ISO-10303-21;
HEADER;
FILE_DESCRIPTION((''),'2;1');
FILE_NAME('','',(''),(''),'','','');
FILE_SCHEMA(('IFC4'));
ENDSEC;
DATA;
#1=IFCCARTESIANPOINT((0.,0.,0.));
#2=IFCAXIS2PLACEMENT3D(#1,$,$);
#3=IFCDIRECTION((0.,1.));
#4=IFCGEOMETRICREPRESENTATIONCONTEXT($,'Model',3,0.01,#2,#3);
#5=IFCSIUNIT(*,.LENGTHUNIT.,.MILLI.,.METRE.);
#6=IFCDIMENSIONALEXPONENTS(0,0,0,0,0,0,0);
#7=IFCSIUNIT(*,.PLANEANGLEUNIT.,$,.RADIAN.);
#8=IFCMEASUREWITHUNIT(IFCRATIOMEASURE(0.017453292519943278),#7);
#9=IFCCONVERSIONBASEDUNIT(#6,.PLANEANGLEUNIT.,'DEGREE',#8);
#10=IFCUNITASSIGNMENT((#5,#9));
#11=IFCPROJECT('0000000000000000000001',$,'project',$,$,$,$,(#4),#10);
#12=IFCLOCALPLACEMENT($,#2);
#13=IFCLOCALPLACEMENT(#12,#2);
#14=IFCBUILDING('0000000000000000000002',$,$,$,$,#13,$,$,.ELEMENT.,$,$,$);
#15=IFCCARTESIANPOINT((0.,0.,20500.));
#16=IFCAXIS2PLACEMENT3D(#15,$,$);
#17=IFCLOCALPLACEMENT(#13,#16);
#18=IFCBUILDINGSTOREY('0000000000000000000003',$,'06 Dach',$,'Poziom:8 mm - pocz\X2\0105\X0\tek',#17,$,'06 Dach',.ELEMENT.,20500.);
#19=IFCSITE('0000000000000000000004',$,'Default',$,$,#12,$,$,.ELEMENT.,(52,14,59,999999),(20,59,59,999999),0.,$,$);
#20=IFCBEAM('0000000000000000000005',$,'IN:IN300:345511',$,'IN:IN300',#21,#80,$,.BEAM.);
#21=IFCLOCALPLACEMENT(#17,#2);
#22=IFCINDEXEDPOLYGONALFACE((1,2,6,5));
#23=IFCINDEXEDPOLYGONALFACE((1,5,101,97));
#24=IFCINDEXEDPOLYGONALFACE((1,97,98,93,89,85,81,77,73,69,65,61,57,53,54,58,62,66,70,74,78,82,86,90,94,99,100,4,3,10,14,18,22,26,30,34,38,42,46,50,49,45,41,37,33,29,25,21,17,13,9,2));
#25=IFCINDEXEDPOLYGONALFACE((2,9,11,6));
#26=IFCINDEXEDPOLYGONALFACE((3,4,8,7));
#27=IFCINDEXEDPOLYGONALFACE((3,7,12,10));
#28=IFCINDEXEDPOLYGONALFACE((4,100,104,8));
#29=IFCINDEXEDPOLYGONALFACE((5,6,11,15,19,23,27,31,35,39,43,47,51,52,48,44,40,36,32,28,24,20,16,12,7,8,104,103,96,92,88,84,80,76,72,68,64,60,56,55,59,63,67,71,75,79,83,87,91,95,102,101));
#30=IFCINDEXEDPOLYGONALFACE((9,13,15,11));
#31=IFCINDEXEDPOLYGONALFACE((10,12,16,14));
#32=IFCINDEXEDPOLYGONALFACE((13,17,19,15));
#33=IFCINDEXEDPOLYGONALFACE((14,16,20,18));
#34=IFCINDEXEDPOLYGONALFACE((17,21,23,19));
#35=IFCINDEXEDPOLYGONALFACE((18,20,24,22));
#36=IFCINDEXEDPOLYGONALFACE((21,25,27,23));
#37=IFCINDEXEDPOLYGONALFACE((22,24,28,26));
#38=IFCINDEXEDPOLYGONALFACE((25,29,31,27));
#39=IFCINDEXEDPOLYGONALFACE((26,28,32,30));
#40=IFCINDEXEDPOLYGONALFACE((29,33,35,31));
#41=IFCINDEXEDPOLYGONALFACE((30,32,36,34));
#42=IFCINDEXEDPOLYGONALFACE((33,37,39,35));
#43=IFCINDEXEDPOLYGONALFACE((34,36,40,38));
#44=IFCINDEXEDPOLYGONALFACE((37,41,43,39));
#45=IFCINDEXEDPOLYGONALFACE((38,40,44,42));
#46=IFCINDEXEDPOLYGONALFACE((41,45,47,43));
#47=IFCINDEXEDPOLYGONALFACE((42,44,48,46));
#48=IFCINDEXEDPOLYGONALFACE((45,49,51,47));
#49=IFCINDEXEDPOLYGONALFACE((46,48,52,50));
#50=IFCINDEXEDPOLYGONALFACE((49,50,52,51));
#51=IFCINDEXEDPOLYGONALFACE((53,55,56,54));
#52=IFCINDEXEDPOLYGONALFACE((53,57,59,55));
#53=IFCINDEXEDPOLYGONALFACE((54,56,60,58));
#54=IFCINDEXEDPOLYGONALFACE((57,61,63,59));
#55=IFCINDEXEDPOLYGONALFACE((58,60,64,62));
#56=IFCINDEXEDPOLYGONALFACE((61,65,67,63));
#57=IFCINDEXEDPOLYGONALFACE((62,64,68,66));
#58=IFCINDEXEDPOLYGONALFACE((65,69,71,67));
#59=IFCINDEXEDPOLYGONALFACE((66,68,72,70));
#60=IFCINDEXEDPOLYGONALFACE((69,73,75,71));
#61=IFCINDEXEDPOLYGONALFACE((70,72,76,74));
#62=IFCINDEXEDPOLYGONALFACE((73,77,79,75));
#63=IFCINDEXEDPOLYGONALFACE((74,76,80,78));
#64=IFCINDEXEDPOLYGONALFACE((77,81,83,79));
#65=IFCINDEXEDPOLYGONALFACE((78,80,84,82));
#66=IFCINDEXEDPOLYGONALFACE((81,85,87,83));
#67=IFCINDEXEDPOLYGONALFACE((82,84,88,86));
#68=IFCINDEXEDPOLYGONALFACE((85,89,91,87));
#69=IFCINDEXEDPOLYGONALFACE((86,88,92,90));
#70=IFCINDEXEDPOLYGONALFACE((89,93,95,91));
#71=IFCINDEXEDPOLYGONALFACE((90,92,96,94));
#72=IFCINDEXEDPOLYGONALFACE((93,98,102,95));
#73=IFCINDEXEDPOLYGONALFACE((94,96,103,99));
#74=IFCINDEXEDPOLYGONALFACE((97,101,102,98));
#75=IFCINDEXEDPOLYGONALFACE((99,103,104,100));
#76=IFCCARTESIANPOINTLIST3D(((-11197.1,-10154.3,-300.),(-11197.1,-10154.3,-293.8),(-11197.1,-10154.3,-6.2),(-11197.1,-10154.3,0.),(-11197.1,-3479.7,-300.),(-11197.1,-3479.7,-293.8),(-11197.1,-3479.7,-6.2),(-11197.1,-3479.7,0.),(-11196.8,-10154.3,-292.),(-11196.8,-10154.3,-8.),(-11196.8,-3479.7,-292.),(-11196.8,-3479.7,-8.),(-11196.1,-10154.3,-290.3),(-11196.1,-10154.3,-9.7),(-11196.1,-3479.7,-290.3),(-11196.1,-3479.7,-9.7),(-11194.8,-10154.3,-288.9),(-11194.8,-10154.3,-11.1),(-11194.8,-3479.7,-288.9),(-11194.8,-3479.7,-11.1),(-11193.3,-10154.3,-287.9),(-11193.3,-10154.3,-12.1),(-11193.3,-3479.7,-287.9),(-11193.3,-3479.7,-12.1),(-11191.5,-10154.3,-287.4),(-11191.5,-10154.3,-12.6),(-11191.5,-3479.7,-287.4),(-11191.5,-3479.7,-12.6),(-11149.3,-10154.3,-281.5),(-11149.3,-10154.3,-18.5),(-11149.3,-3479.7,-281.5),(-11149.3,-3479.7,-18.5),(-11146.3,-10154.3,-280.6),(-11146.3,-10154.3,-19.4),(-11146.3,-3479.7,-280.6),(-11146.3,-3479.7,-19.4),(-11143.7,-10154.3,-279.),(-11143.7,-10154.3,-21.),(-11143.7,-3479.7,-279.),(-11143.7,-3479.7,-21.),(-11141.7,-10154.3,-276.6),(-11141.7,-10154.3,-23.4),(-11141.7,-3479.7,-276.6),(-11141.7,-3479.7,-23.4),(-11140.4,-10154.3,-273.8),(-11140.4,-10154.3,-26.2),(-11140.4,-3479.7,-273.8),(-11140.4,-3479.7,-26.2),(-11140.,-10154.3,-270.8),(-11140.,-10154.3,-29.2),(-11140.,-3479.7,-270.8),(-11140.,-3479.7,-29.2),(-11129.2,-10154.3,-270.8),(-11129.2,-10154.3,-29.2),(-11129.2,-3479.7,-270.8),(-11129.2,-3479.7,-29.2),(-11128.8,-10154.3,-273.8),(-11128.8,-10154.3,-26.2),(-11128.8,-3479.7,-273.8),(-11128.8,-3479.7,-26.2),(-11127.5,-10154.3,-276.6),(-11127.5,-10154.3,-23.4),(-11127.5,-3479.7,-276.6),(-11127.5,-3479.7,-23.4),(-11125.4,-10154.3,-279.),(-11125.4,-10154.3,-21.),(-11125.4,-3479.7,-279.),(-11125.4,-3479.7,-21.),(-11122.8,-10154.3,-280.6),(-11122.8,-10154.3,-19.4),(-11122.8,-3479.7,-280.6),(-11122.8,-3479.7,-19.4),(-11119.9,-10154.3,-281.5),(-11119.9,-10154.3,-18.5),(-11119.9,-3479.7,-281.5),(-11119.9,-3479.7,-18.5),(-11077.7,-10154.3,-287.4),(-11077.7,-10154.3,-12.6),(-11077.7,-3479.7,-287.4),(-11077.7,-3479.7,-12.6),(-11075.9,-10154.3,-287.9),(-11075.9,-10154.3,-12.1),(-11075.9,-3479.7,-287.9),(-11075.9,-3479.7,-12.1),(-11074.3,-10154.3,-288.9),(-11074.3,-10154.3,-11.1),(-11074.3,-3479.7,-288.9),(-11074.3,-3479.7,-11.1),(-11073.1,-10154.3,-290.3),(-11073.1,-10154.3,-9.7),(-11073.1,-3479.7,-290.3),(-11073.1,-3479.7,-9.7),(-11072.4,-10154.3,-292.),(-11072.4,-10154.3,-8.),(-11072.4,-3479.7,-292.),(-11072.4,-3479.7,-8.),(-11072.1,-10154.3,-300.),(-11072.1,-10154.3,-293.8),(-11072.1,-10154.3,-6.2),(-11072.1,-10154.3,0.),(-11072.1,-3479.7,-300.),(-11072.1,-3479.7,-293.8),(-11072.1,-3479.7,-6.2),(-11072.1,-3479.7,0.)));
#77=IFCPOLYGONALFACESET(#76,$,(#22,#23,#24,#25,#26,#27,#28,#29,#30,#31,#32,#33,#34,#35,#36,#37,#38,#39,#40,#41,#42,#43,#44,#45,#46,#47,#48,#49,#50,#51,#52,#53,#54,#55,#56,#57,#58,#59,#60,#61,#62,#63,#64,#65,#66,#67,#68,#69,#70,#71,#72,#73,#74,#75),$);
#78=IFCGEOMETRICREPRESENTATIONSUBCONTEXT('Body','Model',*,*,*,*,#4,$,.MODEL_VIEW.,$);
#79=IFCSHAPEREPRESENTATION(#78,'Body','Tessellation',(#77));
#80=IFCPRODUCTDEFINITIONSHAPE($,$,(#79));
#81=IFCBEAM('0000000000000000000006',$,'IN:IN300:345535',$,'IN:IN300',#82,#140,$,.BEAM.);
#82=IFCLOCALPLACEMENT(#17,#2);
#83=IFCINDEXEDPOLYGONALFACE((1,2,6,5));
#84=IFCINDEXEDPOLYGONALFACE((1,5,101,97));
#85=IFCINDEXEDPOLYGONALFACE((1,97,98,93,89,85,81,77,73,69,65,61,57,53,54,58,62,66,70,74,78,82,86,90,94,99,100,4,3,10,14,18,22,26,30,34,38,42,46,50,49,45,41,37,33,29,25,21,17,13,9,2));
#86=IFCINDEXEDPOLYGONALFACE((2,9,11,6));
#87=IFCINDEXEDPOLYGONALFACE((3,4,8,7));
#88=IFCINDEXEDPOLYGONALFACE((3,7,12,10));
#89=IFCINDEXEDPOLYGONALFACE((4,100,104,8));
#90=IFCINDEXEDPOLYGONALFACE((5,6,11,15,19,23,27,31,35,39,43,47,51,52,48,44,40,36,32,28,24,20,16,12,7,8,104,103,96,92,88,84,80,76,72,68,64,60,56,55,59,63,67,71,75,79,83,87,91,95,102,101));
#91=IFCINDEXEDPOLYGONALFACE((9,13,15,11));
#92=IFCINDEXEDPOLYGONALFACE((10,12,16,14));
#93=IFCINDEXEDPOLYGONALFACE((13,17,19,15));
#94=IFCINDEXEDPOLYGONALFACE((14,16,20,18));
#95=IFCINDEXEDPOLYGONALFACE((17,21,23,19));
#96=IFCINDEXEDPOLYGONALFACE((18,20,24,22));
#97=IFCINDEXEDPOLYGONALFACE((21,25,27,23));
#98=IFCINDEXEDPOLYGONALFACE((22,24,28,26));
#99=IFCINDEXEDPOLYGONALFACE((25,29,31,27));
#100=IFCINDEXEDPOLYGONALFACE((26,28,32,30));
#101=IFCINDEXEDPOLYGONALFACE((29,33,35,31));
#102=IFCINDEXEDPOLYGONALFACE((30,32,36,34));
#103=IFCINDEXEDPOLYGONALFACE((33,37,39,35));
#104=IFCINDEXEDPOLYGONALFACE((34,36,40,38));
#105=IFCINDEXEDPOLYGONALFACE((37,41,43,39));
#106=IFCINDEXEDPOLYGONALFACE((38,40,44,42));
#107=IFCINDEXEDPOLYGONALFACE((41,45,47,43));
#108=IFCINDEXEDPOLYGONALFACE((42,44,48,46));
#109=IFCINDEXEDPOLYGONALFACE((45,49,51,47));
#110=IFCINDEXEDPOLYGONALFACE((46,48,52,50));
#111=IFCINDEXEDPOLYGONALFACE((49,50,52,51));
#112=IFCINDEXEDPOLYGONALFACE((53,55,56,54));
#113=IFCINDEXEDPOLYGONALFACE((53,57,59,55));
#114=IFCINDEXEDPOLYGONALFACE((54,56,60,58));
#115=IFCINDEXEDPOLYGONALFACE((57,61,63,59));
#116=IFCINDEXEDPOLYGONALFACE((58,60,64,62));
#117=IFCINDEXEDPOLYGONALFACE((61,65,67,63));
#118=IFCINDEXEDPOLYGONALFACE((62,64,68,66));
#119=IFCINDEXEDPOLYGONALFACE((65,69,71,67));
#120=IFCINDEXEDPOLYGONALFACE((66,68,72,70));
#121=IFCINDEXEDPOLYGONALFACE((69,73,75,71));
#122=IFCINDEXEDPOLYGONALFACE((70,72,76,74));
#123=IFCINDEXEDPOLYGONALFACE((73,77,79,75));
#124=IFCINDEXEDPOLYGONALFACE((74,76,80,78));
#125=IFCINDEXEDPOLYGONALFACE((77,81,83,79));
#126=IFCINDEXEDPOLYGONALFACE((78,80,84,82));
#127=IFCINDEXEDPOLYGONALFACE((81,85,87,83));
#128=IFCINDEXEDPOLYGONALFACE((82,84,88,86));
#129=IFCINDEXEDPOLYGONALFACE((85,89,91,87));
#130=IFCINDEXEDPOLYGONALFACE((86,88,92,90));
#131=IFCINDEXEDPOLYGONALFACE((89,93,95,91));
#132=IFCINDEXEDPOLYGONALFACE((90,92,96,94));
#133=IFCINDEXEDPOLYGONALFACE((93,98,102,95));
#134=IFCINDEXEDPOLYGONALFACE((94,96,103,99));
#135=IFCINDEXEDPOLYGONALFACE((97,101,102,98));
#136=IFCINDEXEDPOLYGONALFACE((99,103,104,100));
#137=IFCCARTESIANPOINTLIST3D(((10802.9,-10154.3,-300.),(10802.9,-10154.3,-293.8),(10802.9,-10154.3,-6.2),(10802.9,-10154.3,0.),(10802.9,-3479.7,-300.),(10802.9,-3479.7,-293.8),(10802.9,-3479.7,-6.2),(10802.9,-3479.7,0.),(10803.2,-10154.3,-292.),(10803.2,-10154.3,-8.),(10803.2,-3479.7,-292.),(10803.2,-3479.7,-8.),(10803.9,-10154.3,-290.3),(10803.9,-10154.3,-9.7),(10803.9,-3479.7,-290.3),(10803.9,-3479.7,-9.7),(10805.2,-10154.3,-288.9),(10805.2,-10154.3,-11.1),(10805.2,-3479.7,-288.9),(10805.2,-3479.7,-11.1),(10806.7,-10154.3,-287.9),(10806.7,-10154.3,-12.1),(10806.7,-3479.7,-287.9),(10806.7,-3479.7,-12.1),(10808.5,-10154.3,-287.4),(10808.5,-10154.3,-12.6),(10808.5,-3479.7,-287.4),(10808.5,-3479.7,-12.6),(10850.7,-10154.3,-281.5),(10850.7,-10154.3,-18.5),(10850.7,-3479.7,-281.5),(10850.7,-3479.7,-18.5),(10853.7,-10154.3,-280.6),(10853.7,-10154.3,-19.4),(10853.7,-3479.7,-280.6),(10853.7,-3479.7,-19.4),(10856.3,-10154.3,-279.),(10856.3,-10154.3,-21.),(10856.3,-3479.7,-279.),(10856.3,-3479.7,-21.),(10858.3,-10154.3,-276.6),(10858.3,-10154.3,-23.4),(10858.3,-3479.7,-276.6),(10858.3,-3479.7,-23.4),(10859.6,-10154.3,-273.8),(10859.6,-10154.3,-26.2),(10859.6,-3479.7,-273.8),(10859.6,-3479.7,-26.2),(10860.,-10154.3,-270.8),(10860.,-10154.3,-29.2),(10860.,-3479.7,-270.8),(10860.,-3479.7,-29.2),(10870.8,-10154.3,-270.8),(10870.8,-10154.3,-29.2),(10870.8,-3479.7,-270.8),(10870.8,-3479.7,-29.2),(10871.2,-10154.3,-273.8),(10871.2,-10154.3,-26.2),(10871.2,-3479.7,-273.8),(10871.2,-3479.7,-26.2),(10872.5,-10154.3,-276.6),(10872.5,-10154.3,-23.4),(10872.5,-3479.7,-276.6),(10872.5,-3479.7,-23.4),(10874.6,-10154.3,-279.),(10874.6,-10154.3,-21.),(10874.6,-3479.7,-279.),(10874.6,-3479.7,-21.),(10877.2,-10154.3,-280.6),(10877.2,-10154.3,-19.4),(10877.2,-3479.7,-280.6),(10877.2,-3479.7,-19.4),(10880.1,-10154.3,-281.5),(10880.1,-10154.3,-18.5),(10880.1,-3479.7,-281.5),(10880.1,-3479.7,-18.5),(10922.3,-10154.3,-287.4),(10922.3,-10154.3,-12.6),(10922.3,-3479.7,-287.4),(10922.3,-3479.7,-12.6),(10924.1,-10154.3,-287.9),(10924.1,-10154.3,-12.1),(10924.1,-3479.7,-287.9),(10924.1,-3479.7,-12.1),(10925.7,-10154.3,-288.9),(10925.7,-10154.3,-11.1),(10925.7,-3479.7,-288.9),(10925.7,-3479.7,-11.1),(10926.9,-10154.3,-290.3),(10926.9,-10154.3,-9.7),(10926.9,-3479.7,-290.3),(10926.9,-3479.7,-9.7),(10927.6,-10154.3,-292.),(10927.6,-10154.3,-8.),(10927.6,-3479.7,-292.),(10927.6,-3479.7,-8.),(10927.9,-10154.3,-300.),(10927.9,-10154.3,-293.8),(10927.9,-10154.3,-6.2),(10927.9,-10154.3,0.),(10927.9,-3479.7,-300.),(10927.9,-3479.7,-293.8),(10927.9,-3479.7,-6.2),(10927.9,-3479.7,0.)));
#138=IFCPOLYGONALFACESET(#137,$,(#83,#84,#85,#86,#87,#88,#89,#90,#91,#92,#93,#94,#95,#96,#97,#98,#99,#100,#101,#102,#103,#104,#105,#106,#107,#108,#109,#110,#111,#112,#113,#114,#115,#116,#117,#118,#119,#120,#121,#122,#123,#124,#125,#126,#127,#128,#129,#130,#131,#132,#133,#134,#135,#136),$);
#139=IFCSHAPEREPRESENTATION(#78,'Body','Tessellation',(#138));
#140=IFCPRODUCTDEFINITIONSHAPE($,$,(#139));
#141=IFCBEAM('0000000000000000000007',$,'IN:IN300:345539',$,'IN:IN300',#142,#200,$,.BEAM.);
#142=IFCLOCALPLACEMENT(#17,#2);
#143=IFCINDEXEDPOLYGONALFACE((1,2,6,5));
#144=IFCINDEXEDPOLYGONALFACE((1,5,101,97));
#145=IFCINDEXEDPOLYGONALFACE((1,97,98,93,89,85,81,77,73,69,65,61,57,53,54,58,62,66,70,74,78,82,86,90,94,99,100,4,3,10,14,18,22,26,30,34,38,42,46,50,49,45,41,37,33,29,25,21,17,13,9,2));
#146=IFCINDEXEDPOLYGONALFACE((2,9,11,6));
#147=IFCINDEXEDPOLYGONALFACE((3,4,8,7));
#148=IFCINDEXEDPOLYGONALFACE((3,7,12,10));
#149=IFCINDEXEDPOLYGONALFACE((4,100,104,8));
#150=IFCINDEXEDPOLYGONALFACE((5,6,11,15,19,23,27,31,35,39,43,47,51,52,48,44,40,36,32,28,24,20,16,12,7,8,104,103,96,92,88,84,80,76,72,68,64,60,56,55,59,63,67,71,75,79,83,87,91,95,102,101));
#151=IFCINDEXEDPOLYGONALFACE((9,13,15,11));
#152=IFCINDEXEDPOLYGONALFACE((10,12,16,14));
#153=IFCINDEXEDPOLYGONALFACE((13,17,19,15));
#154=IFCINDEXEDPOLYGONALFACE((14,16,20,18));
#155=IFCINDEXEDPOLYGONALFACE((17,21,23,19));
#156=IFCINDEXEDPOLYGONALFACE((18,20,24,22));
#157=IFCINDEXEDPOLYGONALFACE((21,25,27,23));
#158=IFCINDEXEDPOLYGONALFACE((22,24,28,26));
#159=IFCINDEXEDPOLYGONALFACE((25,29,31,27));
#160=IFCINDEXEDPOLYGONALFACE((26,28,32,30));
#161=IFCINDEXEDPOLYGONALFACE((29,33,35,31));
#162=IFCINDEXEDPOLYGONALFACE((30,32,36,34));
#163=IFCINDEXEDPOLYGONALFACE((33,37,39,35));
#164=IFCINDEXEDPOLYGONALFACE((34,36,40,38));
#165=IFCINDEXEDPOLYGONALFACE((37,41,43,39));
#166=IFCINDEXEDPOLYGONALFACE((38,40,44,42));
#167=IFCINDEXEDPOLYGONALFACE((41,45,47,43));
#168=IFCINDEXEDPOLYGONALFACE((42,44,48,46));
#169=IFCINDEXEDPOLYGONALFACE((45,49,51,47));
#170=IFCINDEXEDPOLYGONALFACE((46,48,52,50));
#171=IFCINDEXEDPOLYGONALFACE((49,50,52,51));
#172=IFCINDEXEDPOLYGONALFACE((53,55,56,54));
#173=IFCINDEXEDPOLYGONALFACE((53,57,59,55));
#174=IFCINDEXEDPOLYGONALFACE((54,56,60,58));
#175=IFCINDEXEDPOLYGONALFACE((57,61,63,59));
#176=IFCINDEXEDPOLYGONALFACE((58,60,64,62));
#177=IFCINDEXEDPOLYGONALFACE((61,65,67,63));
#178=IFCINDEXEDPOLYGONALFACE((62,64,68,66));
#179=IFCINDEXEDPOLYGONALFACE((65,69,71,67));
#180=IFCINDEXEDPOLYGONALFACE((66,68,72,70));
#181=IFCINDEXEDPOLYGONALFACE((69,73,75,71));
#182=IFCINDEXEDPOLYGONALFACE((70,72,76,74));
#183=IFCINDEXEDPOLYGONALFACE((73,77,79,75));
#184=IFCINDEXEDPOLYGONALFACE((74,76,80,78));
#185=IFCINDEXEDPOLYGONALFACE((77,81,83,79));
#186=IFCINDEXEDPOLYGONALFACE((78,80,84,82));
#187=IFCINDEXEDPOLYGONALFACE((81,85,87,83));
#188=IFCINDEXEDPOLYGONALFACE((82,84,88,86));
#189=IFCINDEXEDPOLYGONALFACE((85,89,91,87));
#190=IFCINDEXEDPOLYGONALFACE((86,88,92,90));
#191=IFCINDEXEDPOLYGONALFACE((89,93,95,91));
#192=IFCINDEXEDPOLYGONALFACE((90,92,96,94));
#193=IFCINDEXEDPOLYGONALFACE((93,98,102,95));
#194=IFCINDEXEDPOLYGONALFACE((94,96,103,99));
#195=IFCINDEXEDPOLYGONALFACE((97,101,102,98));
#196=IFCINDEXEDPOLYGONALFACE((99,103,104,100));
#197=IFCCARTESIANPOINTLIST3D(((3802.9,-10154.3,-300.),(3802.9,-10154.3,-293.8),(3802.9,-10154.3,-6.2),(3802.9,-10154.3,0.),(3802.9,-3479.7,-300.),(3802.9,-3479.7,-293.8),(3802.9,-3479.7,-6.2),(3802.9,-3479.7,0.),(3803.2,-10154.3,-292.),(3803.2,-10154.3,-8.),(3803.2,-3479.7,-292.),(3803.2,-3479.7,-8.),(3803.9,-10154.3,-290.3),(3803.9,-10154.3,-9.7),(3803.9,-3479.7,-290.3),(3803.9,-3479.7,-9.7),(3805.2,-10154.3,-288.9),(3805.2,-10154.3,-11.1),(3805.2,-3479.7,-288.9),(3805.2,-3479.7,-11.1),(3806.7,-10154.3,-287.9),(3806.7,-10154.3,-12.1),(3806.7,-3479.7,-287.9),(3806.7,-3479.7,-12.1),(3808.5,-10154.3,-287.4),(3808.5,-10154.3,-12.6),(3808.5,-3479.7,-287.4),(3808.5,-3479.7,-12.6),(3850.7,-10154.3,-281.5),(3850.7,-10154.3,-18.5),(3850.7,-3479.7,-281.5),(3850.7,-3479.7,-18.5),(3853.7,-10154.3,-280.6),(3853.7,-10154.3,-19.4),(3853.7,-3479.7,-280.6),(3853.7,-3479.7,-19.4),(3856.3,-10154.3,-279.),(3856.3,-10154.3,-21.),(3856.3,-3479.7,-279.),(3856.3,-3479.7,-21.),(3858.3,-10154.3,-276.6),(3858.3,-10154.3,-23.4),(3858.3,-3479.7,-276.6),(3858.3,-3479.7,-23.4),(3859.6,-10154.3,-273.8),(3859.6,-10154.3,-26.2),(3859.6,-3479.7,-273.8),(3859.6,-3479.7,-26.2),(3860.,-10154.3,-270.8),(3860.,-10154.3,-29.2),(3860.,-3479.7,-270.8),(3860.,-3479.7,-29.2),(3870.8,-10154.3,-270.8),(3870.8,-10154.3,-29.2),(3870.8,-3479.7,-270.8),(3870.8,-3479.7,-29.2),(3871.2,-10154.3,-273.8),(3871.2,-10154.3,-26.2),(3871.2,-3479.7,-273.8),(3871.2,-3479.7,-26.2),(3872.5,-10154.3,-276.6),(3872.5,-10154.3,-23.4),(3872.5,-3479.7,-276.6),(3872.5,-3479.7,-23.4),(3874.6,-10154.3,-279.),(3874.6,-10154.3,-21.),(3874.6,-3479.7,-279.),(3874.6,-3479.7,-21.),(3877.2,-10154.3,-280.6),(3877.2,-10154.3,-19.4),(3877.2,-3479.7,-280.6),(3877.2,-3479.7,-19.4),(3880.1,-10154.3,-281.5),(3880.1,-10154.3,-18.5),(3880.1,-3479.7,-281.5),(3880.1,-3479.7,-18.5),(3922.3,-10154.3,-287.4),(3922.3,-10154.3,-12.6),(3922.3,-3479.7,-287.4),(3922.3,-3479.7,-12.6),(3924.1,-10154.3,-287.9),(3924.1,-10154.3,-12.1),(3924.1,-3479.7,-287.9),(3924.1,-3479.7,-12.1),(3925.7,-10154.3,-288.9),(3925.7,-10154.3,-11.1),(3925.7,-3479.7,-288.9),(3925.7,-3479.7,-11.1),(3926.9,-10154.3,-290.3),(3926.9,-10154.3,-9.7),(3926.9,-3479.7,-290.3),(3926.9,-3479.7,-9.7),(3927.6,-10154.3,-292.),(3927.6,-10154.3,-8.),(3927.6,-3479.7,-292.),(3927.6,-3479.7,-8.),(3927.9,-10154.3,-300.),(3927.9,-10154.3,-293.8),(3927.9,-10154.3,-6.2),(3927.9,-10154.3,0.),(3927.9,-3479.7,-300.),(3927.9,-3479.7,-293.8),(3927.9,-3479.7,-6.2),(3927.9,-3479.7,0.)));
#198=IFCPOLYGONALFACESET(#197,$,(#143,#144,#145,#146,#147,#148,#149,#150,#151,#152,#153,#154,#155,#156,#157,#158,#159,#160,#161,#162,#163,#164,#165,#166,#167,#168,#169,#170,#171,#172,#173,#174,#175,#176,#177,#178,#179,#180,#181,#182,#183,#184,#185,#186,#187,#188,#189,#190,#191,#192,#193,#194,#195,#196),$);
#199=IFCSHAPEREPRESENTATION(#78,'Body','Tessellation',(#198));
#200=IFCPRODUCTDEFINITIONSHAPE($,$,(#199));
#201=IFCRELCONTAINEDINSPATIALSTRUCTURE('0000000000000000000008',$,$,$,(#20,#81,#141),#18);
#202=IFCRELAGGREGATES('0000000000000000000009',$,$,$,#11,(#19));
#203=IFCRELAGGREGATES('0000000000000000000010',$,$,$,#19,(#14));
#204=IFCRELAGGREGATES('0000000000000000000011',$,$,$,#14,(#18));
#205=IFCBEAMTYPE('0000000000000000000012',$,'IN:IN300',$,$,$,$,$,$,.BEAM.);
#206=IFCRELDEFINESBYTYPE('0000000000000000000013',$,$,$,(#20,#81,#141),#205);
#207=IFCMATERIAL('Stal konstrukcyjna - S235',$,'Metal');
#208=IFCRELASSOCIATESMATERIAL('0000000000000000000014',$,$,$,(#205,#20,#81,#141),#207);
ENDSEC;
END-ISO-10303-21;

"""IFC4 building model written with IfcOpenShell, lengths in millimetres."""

from ifc_helpers import new_model, entity, si_unit, converted_unit, direction, frame, origin, place, context, subcontext, project, spatial, line, arc, indexed_curve, outline, extrude, source, transform, mapped, material, type_object, type_shapes, element, save


model = new_model("IFC4")

# Units and contexts
model_context = context("Model", 3, precision=0.01, world=origin(), true_north=direction((0.0, 1.0)))
body_context = subcontext(model_context, "Body", "Model", "MODEL_VIEW")
ifc_project = project(units=[si_unit("LENGTHUNIT", "METRE", prefix="MILLI"), converted_unit("PLANEANGLEUNIT", "DEGREE", entity("IfcRatioMeasure", 0.017453292519943278), si_unit("PLANEANGLEUNIT", "RADIAN"), dimensions=[0, 0, 0, 0, 0, 0, 0])], contexts=[model_context])

# Site, building, storey
site_placement = place(None, origin())
site = spatial("IfcSite", under=ifc_project, at=site_placement, Name="Default", CompositionType="ELEMENT", RefLatitude=(52, 14, 59, 999999), RefLongitude=(20, 59, 59, 999999), RefElevation=0.0)
building_placement = place(site_placement, origin())
building = spatial("IfcBuilding", under=site, at=building_placement, CompositionType="ELEMENT")
storey_placement = place(building_placement, frame((0.0, 0.0, 20500.0)))
storey = spatial("IfcBuildingStorey", under=building, at=storey_placement, Name="06 Dach", ObjectType="Poziom:8 mm - początek", LongName="06 Dach", CompositionType="ELEMENT", Elevation=20500.0)

# Beams
ifc_material_1 = material(Name="Stal konstrukcyjna - S235", Category="Metal")
beam_type_1 = type_object("IfcBeamType", Name="IN:IN300", PredefinedType="BEAM", material=ifc_material_1)
shared_shape_1 = source(origin(), body_context, "Body", "SweptSolid", [
    extrude(outline(indexed_curve([(143.8, -62.5), (150.0, -62.5), (150.0, 62.5), (143.8, 62.5), (139.6, 60.9), (137.4, 56.9), (131.5, 14.7), (127.9, 8.1), (120.8, 5.4), (-120.8, 5.4), (-127.9, 8.1), (-131.5, 14.7), (-137.4, 56.9), (-139.6, 60.9), (-143.8, 62.5), (-150.0, 62.5), (-150.0, -62.5), (-143.8, -62.5), (-139.6, -60.9), (-137.4, -56.9), (-131.5, -14.7), (-127.9, -8.1), (-120.8, -5.4), (120.8, -5.4), (127.9, -8.1), (131.5, -14.7), (137.4, -56.9), (139.6, -60.9)], segments=[line(1, 2, 3, 4), arc(4, 5, 6), line(6, 7), arc(7, 8, 9), line(9, 10), arc(10, 11, 12), line(12, 13), arc(13, 14, 15), line(15, 16, 17, 18), arc(18, 19, 20), line(20, 21), arc(21, 22, 23), line(23, 24), arc(24, 25, 26), line(26, 27), arc(27, 28, 1)], self_intersect=False)), frame((-3337.3, 0.0, 0.0), z_axis=(1.0, 0.0, 0.0), x_axis=(0.0, 0.0, -1.0)), (0.0, 0.0, 1.0), 6674.6),
])
type_shapes(beam_type_1, [shared_shape_1])
for number, where, z_axis, x_axis, name in (
    (1, (-11134.6, -6817.0, -150.0), (0.0, 0.0, 1.0), (0.0, 1.0, 0.0), "IN:IN300:345511"),
    (2, (10865.4, -6817.0, -150.0), (0.0, 0.0, 1.0), (0.0, -1.0, 0.0), "IN:IN300:345535"),
    (3, (3865.4, -6817.0, -150.0), (0.0, 0.0, 1.0), (0.0, -1.0, 0.0), "IN:IN300:345539"),
):
    element("IfcBeam", number, at=place(storey_placement, frame(where, z_axis=z_axis, x_axis=x_axis)), inside=storey, type_object=beam_type_1, material=ifc_material_1, Name=name, ObjectType="IN:IN300", PredefinedType="BEAM", context=body_context, shape_type="MappedRepresentation", body=[
        mapped(shared_shape_1, transform((0.0, 0.0, 0.0), scale=1.0)),
    ])

save(model, "model.ifc")
